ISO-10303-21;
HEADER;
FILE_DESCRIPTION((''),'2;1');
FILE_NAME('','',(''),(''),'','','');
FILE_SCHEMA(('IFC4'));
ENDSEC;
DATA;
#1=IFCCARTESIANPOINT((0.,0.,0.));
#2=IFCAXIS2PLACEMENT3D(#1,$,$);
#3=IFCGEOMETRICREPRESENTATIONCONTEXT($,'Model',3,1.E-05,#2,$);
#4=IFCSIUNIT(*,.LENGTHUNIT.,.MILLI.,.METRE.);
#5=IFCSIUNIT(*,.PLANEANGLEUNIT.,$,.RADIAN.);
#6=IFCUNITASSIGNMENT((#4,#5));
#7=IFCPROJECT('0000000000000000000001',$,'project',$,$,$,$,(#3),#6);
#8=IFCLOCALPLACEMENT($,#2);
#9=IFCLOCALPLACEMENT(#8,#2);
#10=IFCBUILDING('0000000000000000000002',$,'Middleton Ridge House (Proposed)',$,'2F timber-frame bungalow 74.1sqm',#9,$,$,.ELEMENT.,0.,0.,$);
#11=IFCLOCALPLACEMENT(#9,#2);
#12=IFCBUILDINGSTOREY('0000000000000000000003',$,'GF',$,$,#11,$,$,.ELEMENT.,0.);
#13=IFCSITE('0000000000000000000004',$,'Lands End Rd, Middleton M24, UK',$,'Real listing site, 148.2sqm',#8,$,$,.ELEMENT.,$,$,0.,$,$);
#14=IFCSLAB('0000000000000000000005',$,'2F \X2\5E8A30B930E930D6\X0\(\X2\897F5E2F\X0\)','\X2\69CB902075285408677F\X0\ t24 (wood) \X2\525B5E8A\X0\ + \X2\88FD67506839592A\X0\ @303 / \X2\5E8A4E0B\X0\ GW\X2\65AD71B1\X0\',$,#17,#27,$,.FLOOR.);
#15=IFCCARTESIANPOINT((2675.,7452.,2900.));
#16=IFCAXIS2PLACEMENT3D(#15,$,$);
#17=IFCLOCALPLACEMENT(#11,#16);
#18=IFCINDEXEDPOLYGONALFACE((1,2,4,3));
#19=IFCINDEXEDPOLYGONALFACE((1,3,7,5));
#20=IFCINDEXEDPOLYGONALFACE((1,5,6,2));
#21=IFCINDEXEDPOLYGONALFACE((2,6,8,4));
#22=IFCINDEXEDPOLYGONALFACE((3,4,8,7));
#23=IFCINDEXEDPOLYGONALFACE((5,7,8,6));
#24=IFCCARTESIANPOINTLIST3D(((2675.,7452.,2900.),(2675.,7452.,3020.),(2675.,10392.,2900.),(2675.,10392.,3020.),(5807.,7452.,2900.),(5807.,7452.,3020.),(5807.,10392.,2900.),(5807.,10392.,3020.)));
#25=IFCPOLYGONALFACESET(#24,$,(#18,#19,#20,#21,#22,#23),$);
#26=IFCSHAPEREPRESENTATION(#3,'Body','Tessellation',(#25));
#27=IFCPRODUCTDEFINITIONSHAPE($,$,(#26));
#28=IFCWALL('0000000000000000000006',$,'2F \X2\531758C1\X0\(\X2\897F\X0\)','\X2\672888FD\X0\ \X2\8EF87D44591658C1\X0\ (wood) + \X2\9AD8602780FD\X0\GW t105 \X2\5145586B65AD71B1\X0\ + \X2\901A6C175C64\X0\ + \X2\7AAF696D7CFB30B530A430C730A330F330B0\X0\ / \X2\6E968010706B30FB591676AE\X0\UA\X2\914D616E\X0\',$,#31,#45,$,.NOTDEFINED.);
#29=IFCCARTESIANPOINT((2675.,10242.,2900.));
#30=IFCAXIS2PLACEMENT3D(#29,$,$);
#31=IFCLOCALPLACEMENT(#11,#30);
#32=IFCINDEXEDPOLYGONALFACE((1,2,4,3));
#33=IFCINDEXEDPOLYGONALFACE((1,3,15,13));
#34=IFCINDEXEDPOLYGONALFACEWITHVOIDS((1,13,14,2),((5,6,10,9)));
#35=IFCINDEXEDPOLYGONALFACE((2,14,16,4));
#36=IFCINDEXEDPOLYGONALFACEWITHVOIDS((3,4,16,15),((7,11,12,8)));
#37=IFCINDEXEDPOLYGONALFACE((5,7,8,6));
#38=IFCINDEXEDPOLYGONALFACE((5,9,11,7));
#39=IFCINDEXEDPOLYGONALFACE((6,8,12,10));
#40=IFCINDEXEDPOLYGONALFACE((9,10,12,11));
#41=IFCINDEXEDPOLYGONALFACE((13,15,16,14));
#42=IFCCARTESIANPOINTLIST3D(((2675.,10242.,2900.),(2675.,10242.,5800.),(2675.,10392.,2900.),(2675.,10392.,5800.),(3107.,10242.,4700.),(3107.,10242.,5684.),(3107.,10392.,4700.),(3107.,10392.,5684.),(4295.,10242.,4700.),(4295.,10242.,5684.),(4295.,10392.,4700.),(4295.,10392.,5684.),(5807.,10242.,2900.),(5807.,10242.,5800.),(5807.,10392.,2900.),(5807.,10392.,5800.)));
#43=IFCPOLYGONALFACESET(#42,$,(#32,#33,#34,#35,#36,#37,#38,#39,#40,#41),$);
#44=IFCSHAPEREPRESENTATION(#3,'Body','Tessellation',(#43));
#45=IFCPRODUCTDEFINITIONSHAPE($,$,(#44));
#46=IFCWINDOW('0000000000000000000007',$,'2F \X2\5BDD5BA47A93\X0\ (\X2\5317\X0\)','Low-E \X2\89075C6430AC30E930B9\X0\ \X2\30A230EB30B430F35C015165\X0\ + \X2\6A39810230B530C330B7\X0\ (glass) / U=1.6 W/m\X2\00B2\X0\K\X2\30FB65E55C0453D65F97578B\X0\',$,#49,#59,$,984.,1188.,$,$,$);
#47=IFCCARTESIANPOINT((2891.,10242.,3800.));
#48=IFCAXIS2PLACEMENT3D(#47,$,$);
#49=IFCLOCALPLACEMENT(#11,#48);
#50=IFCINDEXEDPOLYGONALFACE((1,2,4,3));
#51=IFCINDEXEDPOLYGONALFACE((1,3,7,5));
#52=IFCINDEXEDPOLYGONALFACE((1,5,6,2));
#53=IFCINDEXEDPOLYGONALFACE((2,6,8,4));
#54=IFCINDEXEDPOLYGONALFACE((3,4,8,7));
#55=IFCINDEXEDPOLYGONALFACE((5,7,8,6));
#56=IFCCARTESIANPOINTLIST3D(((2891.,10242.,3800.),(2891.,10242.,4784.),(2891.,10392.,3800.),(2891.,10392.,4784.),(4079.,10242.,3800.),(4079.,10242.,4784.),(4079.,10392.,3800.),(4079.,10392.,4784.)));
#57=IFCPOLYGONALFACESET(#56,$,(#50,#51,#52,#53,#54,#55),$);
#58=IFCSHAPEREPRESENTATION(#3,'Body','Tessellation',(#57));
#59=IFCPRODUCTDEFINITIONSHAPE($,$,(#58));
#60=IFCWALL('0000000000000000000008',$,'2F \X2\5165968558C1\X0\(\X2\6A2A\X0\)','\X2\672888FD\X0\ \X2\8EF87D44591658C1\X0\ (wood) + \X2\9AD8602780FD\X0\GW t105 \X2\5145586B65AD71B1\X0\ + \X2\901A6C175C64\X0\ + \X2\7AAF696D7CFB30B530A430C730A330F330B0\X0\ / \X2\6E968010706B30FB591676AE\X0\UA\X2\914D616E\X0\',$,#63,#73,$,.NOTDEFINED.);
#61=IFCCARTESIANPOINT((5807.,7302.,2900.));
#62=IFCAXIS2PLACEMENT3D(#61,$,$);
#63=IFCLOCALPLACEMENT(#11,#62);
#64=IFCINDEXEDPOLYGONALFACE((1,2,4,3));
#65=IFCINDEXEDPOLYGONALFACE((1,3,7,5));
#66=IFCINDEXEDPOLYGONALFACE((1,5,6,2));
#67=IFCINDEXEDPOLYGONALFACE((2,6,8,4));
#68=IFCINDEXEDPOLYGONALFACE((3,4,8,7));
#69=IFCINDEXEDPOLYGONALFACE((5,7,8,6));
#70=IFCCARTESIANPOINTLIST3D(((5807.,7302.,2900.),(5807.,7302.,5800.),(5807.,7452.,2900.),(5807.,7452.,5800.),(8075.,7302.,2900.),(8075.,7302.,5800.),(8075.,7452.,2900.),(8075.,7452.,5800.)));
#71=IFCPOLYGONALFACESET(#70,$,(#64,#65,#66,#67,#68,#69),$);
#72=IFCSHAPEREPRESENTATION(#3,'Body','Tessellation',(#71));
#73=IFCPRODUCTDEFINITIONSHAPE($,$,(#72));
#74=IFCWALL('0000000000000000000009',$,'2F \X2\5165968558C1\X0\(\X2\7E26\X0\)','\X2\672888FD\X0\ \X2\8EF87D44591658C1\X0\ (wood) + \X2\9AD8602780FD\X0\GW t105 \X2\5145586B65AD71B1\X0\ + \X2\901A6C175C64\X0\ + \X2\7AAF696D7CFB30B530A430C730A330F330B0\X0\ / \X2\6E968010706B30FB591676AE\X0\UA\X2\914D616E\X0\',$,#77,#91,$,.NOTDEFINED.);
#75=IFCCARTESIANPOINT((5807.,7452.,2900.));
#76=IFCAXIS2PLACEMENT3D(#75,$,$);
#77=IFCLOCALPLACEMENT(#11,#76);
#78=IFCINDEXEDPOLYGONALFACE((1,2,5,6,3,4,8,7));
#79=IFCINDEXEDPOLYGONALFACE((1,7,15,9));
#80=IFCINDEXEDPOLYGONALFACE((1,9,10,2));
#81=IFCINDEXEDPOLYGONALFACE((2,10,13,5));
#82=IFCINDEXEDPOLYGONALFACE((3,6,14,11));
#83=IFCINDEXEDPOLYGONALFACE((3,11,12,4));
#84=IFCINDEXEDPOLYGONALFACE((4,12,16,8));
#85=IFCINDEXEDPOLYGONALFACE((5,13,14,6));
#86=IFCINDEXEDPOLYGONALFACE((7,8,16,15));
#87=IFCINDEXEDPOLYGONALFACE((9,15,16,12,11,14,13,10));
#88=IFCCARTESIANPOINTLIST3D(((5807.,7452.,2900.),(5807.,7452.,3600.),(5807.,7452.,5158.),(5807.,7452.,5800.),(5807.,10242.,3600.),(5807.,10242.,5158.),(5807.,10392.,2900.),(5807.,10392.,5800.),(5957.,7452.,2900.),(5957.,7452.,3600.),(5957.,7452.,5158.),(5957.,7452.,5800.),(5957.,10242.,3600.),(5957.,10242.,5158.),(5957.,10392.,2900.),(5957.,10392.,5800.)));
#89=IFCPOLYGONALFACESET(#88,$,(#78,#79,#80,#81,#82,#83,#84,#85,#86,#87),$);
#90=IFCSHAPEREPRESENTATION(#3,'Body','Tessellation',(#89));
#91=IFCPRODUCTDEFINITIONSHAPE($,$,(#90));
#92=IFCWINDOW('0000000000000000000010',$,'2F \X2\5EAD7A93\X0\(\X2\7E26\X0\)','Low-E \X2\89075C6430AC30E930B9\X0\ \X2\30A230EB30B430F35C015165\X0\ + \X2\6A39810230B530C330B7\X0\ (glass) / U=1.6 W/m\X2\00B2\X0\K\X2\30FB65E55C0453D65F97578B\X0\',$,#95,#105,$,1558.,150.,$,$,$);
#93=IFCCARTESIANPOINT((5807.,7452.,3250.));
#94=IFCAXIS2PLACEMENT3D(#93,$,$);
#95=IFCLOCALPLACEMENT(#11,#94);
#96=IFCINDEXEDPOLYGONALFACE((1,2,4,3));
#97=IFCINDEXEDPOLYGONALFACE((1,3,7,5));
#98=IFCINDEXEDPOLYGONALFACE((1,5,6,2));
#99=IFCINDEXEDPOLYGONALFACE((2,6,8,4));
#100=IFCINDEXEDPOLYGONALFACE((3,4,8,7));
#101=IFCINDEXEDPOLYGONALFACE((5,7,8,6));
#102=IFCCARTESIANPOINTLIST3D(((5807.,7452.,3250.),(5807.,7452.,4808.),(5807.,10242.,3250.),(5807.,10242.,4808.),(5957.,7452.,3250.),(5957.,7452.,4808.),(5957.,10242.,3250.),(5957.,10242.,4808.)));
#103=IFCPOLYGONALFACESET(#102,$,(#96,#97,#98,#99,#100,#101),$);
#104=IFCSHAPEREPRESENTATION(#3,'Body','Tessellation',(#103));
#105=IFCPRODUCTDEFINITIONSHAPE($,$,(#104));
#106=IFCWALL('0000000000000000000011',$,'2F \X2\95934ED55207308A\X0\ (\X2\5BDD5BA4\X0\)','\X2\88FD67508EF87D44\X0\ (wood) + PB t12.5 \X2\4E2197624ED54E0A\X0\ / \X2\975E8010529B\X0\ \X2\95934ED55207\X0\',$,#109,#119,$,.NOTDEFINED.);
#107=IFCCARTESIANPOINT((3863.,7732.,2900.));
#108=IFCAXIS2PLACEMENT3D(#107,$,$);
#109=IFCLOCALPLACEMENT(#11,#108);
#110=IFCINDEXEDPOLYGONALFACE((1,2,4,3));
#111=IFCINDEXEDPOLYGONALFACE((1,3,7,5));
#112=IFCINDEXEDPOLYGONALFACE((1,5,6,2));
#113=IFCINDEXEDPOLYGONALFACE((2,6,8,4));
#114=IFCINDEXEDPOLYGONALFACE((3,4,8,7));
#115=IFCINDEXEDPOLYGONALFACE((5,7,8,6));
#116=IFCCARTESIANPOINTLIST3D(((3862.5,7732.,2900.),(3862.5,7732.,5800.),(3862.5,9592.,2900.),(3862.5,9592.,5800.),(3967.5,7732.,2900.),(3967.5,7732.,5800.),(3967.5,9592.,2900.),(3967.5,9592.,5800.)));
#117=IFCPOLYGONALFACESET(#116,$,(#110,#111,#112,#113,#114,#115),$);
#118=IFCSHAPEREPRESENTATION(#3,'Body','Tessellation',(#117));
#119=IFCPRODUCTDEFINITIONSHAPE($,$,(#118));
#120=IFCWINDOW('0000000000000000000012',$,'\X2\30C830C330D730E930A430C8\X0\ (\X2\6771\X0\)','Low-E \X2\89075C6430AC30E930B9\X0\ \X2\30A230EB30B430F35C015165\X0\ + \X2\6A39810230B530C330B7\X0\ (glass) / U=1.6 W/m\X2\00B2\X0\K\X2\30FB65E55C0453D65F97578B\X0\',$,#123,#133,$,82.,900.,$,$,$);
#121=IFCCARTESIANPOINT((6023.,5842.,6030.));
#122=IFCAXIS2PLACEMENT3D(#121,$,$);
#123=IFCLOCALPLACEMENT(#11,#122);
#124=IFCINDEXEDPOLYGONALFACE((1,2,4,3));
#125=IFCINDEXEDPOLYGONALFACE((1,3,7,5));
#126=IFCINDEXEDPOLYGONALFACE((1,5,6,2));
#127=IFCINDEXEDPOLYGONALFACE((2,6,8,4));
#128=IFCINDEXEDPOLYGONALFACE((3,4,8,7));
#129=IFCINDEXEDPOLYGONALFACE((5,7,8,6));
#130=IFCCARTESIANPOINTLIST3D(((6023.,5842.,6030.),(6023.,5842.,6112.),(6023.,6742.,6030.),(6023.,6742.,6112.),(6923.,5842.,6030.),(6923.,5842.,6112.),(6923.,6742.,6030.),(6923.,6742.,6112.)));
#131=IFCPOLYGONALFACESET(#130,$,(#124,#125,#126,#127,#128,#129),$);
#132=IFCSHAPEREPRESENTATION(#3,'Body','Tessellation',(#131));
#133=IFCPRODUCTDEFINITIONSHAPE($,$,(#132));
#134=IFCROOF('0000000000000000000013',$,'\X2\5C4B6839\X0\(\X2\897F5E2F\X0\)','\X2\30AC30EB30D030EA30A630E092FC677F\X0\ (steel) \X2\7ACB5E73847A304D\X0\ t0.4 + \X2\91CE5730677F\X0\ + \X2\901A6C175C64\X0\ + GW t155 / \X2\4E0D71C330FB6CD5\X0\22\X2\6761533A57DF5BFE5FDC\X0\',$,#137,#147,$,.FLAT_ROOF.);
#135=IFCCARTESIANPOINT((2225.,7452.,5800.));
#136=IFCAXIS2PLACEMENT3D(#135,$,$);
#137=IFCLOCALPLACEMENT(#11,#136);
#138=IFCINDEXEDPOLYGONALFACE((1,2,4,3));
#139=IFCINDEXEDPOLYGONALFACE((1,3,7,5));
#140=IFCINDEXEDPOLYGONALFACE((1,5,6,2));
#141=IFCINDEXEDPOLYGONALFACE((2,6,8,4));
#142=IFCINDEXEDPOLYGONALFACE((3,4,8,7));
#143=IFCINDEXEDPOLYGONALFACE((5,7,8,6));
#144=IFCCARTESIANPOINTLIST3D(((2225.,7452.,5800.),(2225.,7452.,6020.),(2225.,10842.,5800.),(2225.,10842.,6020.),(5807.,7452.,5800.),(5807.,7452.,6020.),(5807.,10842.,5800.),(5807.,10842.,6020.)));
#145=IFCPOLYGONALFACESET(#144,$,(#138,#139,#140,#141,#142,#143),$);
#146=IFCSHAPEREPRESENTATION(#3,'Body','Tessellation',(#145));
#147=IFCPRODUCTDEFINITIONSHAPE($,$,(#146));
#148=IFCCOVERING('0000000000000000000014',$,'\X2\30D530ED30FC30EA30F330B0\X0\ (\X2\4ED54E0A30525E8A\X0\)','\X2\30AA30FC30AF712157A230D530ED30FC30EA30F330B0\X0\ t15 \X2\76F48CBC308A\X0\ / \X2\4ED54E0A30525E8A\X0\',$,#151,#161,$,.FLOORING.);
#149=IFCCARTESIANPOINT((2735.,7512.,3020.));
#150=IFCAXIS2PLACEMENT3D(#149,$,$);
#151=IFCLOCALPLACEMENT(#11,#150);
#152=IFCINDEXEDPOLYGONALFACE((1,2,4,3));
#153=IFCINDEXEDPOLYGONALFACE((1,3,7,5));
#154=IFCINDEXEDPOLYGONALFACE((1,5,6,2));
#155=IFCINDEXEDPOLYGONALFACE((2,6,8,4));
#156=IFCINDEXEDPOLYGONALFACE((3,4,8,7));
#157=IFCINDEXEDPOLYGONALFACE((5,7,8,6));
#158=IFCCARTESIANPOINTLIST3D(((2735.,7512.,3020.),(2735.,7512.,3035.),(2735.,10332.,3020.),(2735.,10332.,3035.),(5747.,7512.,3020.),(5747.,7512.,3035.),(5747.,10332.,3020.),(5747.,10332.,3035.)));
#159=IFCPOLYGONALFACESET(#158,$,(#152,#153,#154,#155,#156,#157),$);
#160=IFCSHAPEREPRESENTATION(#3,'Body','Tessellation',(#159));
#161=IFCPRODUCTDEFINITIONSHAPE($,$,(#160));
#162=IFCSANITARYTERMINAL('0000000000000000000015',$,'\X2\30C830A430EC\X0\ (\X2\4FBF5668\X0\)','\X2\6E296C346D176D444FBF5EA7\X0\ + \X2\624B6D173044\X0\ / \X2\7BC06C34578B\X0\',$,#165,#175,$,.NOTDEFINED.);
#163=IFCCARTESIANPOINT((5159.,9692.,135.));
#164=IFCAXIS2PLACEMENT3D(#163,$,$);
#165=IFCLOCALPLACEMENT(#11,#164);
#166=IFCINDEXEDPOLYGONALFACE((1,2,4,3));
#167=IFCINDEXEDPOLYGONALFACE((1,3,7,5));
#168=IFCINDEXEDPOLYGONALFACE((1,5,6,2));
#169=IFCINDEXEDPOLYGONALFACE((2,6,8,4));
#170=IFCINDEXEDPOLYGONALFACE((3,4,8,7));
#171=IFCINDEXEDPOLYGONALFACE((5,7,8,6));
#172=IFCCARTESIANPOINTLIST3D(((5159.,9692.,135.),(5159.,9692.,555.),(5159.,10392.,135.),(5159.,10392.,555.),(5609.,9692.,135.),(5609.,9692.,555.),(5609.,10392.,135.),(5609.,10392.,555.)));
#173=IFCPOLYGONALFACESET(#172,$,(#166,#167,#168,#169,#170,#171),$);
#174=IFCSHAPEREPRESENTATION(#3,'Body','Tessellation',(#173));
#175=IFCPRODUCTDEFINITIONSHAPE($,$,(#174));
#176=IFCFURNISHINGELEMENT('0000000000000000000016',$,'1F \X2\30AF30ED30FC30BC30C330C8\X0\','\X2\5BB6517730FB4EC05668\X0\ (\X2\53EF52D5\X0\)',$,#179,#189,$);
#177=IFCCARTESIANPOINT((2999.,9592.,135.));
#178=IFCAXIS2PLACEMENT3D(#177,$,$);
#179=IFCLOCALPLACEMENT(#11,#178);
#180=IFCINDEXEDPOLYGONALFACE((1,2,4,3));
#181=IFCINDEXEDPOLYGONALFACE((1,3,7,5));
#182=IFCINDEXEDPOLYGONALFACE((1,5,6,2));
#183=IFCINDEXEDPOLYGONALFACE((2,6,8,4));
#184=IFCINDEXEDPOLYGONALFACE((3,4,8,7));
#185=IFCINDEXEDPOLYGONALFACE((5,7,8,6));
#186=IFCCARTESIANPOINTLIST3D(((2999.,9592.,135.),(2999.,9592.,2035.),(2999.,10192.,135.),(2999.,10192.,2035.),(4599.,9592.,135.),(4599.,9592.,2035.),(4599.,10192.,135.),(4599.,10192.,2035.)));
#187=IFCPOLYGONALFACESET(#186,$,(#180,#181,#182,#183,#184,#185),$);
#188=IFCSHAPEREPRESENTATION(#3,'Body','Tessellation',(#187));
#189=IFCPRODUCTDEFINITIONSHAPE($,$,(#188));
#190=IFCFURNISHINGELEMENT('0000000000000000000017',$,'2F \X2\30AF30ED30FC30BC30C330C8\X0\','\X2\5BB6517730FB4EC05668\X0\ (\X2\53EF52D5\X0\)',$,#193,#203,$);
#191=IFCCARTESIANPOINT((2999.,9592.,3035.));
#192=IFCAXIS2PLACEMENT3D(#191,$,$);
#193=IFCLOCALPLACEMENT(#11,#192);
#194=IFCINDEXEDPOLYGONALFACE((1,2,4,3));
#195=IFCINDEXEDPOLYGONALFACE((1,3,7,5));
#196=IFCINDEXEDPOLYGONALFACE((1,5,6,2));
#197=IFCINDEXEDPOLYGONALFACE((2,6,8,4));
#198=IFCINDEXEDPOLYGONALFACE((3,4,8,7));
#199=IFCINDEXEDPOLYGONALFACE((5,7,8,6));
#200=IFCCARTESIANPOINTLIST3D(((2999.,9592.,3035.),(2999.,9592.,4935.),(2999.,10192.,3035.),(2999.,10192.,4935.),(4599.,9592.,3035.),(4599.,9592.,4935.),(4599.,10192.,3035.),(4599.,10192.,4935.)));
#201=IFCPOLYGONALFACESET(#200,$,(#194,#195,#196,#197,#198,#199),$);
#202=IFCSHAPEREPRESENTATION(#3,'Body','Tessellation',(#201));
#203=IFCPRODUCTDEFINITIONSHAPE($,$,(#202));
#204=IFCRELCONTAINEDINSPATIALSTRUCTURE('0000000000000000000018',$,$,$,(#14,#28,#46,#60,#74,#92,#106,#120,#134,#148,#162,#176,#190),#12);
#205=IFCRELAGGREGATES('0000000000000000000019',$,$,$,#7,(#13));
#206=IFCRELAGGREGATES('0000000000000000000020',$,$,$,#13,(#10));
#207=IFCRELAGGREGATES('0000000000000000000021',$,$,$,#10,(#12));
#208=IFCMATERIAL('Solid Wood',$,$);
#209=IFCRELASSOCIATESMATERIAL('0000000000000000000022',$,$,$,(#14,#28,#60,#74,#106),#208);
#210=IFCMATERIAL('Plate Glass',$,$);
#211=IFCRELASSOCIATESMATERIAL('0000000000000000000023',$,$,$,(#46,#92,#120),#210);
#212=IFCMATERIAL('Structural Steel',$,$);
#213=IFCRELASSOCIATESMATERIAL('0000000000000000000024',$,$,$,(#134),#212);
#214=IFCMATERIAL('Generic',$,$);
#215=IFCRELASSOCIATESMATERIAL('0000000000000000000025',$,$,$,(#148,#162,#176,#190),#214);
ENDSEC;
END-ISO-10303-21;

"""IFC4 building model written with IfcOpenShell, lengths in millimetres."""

from ifc_helpers import new_model, si_unit, frame, frame_2d, origin, place, context, project, spatial, rectangle, extrude, material, element, fill, save


model = new_model("IFC4")

# Units and contexts
model_context = context("Model", 3, precision=1e-05, world=origin())
ifc_project = project(units=[si_unit("LENGTHUNIT", "METRE", prefix="MILLI"), si_unit("PLANEANGLEUNIT", "RADIAN")], contexts=[model_context])

# Site, building, storey
site_placement = place(None, origin())
site = spatial("IfcSite", under=ifc_project, at=site_placement, Name="Lands End Rd, Middleton M24, UK", ObjectType="Real listing site, 148.2sqm", CompositionType="ELEMENT", RefElevation=0.0)
building_placement = place(site_placement, origin())
building = spatial("IfcBuilding", under=site, at=building_placement, Name="Middleton Ridge House (Proposed)", ObjectType="2F timber-frame bungalow 74.1sqm", CompositionType="ELEMENT", ElevationOfRefHeight=0.0, ElevationOfTerrain=0.0)
storey_placement = place(building_placement, origin())
storey = spatial("IfcBuildingStorey", under=building, at=storey_placement, Name="GF", CompositionType="ELEMENT", Elevation=0.0)

# Slab
ifc_material_1 = material(Name="Solid Wood")
slab_placement = place(storey_placement, frame((2675.0, 7452.0, 2900.0)))
element("IfcSlab", 1, at=slab_placement, inside=storey, material=ifc_material_1, Name="2F 床スラブ(西帯)", Description="構造用合板 t24 (wood) 剛床 + 製材根太 @303 / 床下 GW断熱", PredefinedType="FLOOR", context=model_context, shape_type="SweptSolid", body=[
    extrude(rectangle(XDim=3132.0, YDim=2940.0, at=frame_2d((1566.0, 1470.0))), frame((2675.0, 7452.0, 2900.0)), (0.0, 0.0, 1.0), 120.0),
])

# Wall, opening, window
wall_1_placement = place(storey_placement, frame((2675.0, 10242.0, 2900.0)))
wall_1 = element("IfcWall", 2, at=wall_1_placement, inside=storey, material=ifc_material_1, Name="2F 北壁(西)", Description="木製 軸組外壁 (wood) + 高性能GW t105 充填断熱 + 通気層 + 窯業系サイディング / 準耐火・外皮UA配慮", PredefinedType="NOTDEFINED", context=model_context, shape_type="SweptSolid", body=[
    extrude(rectangle(XDim=3132.0, YDim=150.0, at=frame_2d((1566.0, 75.0))), frame((2675.0, 10242.0, 2900.0)), (0.0, 0.0, 1.0), 2900.0),
])
opening_1_placement = place(storey_placement, frame((2891.0, 10242.0, 3800.0)))
opening_1 = element("IfcOpeningElement", 3, at=opening_1_placement, cuts=wall_1, PredefinedType="NOTDEFINED", context=model_context, shape_type="SweptSolid", body=[
    extrude(rectangle(XDim=1188.0, YDim=150.0, at=frame_2d((594.0, 75.0))), frame((2891.0, 10242.0, 3800.0)), (0.0, 0.0, 1.0), 984.0),
])
ifc_material_2 = material(Name="Plate Glass")
window_1_placement = place(storey_placement, frame((2891.0, 10242.0, 3800.0)))
window_1 = element("IfcWindow", 4, at=window_1_placement, inside=storey, material=ifc_material_2, Name="2F 寝室窓 (北)", Description="Low-E 複層ガラス アルゴン封入 + 樹脂サッシ (glass) / U=1.6 W/m²K・日射取得型", OverallHeight=984.0, OverallWidth=1188.0, context=model_context, shape_type="SweptSolid", body=[
    extrude(rectangle(XDim=1188.0, YDim=150.0, at=frame_2d((594.0, 75.0))), frame((2891.0, 10242.0, 3800.0)), (0.0, 0.0, 1.0), 984.0),
])
fill(opening_1, window_1)

# Wall
wall_2_placement = place(storey_placement, frame((5807.0, 7302.0, 2900.0)))
element("IfcWall", 5, at=wall_2_placement, inside=storey, material=ifc_material_1, Name="2F 入隅壁(横)", Description="木製 軸組外壁 (wood) + 高性能GW t105 充填断熱 + 通気層 + 窯業系サイディング / 準耐火・外皮UA配慮", PredefinedType="NOTDEFINED", context=model_context, shape_type="SweptSolid", body=[
    extrude(rectangle(XDim=2268.0, YDim=150.0, at=frame_2d((1134.0, 75.0))), frame((5807.0, 7302.0, 2900.0)), (0.0, 0.0, 1.0), 2900.0),
])

# Wall, opening, window
wall_3_placement = place(storey_placement, frame((5807.0, 7452.0, 2900.0)))
wall_3 = element("IfcWall", 6, at=wall_3_placement, inside=storey, material=ifc_material_1, Name="2F 入隅壁(縦)", Description="木製 軸組外壁 (wood) + 高性能GW t105 充填断熱 + 通気層 + 窯業系サイディング / 準耐火・外皮UA配慮", PredefinedType="NOTDEFINED", context=model_context, shape_type="SweptSolid", body=[
    extrude(rectangle(XDim=150.0, YDim=2940.0, at=frame_2d((75.0, 1470.0))), frame((5807.0, 7452.0, 2900.0)), (0.0, 0.0, 1.0), 2900.0),
])
opening_2_placement = place(storey_placement, frame((5807.0, 7452.0, 3250.0)))
opening_2 = element("IfcOpeningElement", 7, at=opening_2_placement, cuts=wall_3, PredefinedType="NOTDEFINED", context=model_context, shape_type="SweptSolid", body=[
    extrude(rectangle(XDim=150.0, YDim=2790.0, at=frame_2d((75.0, 1395.0))), frame((5807.0, 7452.0, 3250.0)), (0.0, 0.0, 1.0), 1558.0),
])
window_2_placement = place(storey_placement, frame((5807.0, 7452.0, 3250.0)))
window_2 = element("IfcWindow", 8, at=window_2_placement, inside=storey, material=ifc_material_2, Name="2F 庭窓(縦)", Description="Low-E 複層ガラス アルゴン封入 + 樹脂サッシ (glass) / U=1.6 W/m²K・日射取得型", OverallHeight=1558.0, OverallWidth=150.0, context=model_context, shape_type="SweptSolid", body=[
    extrude(rectangle(XDim=150.0, YDim=2790.0, at=frame_2d((75.0, 1395.0))), frame((5807.0, 7452.0, 3250.0)), (0.0, 0.0, 1.0), 1558.0),
])
fill(opening_2, window_2)

# Wall
wall_4_placement = place(storey_placement, frame((3863.0, 7732.0, 2900.0)))
element("IfcWall", 9, at=wall_4_placement, inside=storey, material=ifc_material_1, Name="2F 間仕切り (寝室)", Description="製材軸組 (wood) + PB t12.5 両面仕上 / 非耐力 間仕切", PredefinedType="NOTDEFINED", context=model_context, shape_type="SweptSolid", body=[
    extrude(rectangle(XDim=105.0, YDim=1860.0, at=frame_2d((52.0, 930.0))), frame((3863.0, 7732.0, 2900.0)), (0.0, 0.0, 1.0), 2900.0),
])

# Window
window_3_placement = place(storey_placement, frame((6023.0, 5842.0, 6030.0)))
element("IfcWindow", 10, at=window_3_placement, inside=storey, material=ifc_material_2, Name="トップライト (東)", Description="Low-E 複層ガラス アルゴン封入 + 樹脂サッシ (glass) / U=1.6 W/m²K・日射取得型", OverallHeight=82.0, OverallWidth=900.0, context=model_context, shape_type="SweptSolid", body=[
    extrude(rectangle(XDim=900.0, YDim=900.0, at=frame_2d((450.0, 450.0))), frame((6023.0, 5842.0, 6030.0)), (0.0, 0.0, 1.0), 82.0),
])

# Roof
ifc_material_3 = material(Name="Structural Steel")
for number, where, name in (
    (11, (2225.0, 7452.0, 5800.0), "屋根(西帯)"),
):
    element("IfcRoof", number, at=place(storey_placement, frame(where)), inside=storey, material=ifc_material_3, Name=name, Description="ガルバリウム鋼板 (steel) 立平葺き t0.4 + 野地板 + 通気層 + GW t155 / 不燃・法22条区域対応", PredefinedType="FLAT_ROOF", context=model_context, shape_type="SweptSolid", body=[
        extrude(rectangle(XDim=3582.0, YDim=3390.0, at=frame_2d((1791.0, 1695.0))), frame((2225.0, 7452.0, 5800.0)), (0.0, 0.0, 1.0), 220.0),
    ])

# Covering
ifc_material_4 = material(Name="Generic")
covering_placement = place(storey_placement, frame((2735.0, 7512.0, 3020.0)))
element("IfcCovering", 12, at=covering_placement, inside=storey, material=ifc_material_4, Name="フローリング (仕上げ床)", Description="オーク無垢フローリング t15 直貼り / 仕上げ床", PredefinedType="FLOORING", context=model_context, shape_type="SweptSolid", body=[
    extrude(rectangle(XDim=3012.0, YDim=2820.0, at=frame_2d((1506.0, 1410.0))), frame((2735.0, 7512.0, 3020.0)), (0.0, 0.0, 1.0), 15.0),
])

# Sanitary terminal
sanitary_terminal_placement = place(storey_placement, frame((5159.0, 9692.0, 135.0)))
element("IfcSanitaryTerminal", 13, at=sanitary_terminal_placement, inside=storey, material=ifc_material_4, Name="トイレ (便器)", Description="温水洗浄便座 + 手洗い / 節水型", PredefinedType="NOTDEFINED", context=model_context, shape_type="SweptSolid", body=[
    extrude(rectangle(XDim=450.0, YDim=700.0, at=frame_2d((225.0, 350.0))), frame((5159.0, 9692.0, 135.0)), (0.0, 0.0, 1.0), 420.0),
])

# Furnishing elements
furnishing_1_placement = place(storey_placement, frame((2999.0, 9592.0, 135.0)))
element("IfcFurnishingElement", 14, at=furnishing_1_placement, inside=storey, material=ifc_material_4, Name="1F クローゼット", Description="家具・什器 (可動)", context=model_context, shape_type="SweptSolid", body=[
    extrude(rectangle(XDim=1600.0, YDim=600.0, at=frame_2d((800.0, 300.0))), frame((2999.0, 9592.0, 135.0)), (0.0, 0.0, 1.0), 1900.0),
])
furnishing_2_placement = place(storey_placement, frame((2999.0, 9592.0, 3035.0)))
element("IfcFurnishingElement", 15, at=furnishing_2_placement, inside=storey, material=ifc_material_4, Name="2F クローゼット", Description="家具・什器 (可動)", context=model_context, shape_type="SweptSolid", body=[
    extrude(rectangle(XDim=1600.0, YDim=600.0, at=frame_2d((800.0, 300.0))), frame((2999.0, 9592.0, 3035.0)), (0.0, 0.0, 1.0), 1900.0),
])

save(model, "model.ifc")
